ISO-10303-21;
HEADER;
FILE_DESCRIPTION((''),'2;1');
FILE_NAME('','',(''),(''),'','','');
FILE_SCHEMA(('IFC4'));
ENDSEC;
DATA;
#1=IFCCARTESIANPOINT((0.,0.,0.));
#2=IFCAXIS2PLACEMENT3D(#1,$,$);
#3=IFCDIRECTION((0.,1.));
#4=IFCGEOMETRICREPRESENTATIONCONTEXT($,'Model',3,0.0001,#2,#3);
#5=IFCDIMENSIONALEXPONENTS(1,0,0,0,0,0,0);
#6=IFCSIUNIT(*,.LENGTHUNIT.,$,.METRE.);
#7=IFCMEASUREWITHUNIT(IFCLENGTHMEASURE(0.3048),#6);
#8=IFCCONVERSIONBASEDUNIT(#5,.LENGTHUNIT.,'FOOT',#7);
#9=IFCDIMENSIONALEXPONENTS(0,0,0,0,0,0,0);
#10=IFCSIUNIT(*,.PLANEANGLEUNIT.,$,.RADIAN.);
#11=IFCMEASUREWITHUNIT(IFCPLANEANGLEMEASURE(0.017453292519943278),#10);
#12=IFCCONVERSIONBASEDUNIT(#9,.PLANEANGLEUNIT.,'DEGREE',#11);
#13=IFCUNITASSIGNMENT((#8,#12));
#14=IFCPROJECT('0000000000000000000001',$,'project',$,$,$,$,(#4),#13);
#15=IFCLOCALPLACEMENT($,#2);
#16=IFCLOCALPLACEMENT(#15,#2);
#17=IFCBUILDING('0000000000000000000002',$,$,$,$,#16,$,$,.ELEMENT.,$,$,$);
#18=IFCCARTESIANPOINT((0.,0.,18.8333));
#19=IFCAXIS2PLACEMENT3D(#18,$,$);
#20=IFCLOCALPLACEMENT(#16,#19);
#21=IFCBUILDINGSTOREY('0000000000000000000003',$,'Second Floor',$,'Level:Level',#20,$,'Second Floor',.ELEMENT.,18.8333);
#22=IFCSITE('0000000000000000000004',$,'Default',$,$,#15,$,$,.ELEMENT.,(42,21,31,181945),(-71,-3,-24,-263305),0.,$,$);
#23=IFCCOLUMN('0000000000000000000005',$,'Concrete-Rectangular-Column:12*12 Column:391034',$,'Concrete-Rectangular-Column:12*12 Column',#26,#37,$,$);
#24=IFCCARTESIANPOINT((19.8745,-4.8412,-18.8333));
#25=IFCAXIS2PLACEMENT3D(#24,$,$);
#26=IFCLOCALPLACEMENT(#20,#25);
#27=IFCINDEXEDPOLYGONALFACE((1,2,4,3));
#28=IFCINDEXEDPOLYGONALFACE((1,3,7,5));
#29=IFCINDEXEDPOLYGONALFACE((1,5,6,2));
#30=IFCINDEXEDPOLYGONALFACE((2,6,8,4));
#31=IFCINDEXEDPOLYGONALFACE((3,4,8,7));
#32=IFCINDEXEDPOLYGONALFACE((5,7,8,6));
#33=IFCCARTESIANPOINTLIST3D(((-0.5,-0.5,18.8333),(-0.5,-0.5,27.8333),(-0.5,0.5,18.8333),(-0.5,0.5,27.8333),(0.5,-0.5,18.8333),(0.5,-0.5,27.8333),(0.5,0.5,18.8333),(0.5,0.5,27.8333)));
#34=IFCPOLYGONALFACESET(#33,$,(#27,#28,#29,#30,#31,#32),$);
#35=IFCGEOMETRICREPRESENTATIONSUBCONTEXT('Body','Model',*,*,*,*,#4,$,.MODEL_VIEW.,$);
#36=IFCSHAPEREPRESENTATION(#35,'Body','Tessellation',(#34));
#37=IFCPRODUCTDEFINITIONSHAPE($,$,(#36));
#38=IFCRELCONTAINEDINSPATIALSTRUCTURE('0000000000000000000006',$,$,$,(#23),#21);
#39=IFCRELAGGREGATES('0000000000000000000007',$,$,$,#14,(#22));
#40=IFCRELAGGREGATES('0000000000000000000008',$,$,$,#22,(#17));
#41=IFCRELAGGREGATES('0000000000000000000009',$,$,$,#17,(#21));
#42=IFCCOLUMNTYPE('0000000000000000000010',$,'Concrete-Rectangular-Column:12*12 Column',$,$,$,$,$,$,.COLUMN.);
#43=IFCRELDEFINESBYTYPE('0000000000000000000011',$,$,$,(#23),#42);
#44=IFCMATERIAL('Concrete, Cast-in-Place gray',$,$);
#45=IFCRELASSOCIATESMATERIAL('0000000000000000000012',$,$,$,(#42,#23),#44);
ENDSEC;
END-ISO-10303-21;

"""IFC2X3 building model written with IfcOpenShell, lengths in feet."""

from ifc_helpers import new_model, entity, si_unit, converted_unit, direction, frame, origin, origin_2d_with_axis, place, context, subcontext, project, spatial, rectangle, extrude, source, transform, mapped, material, type_object, type_shapes, element, save


model = new_model("IFC2X3")

# Units and contexts
model_context = context("Model", 3, precision=0.0001, world=origin(), true_north=direction((0.0, 1.0)))
body_context = subcontext(model_context, "Body", "Model", "MODEL_VIEW")
ifc_project = project(units=[converted_unit("LENGTHUNIT", "FOOT", entity("IfcLengthMeasure", 0.3048), si_unit("LENGTHUNIT", "METRE"), dimensions=[1, 0, 0, 0, 0, 0, 0]), converted_unit("PLANEANGLEUNIT", "DEGREE", entity("IfcPlaneAngleMeasure", 0.017453292519943278), si_unit("PLANEANGLEUNIT", "RADIAN"), dimensions=[0, 0, 0, 0, 0, 0, 0])], contexts=[model_context])

# Site, building, storey
site_placement = place(None, origin())
site = spatial("IfcSite", under=ifc_project, at=site_placement, Name="Default", CompositionType="ELEMENT", RefLatitude=(42, 21, 31, 181945), RefLongitude=(-71, -3, -24, -263305), RefElevation=0.0)
building_placement = place(site_placement, origin())
building = spatial("IfcBuilding", under=site, at=building_placement, CompositionType="ELEMENT")
storey_placement = place(building_placement, frame((0.0, 0.0, 18.8333)))
storey = spatial("IfcBuildingStorey", under=building, at=storey_placement, Name="Second Floor", ObjectType="Level:Level", LongName="Second Floor", CompositionType="ELEMENT", Elevation=18.8333)

# Column
ifc_material_1 = material(Name="Concrete, Cast-in-Place gray")
column_type = type_object("IfcColumnType", Name="Concrete-Rectangular-Column:12*12 Column", PredefinedType="COLUMN", material=ifc_material_1)
shared_shape = source(origin(), body_context, "Body", "SweptSolid", [
    extrude(rectangle(XDim=1.0, YDim=1.0, at=origin_2d_with_axis()), frame((0.0, 0.0, 18.8333), z_axis=(0.0, 0.0, 1.0), x_axis=(-1.0, 0.0, 0.0)), (0.0, 0.0, 1.0), 9.0),
])
type_shapes(column_type, [shared_shape])
for number, where, name in (
    (1, (19.8745, -4.8412, -18.8333), "Concrete-Rectangular-Column:12*12 Column:391034"),
):
    element("IfcColumn", number, at=place(storey_placement, frame(where)), inside=storey, type_object=column_type, material=ifc_material_1, Name=name, ObjectType="Concrete-Rectangular-Column:12*12 Column", context=body_context, shape_type="MappedRepresentation", body=[
        mapped(shared_shape, transform((0.0, 0.0, 0.0), scale=1.0)),
    ])

save(model, "model.ifc")
